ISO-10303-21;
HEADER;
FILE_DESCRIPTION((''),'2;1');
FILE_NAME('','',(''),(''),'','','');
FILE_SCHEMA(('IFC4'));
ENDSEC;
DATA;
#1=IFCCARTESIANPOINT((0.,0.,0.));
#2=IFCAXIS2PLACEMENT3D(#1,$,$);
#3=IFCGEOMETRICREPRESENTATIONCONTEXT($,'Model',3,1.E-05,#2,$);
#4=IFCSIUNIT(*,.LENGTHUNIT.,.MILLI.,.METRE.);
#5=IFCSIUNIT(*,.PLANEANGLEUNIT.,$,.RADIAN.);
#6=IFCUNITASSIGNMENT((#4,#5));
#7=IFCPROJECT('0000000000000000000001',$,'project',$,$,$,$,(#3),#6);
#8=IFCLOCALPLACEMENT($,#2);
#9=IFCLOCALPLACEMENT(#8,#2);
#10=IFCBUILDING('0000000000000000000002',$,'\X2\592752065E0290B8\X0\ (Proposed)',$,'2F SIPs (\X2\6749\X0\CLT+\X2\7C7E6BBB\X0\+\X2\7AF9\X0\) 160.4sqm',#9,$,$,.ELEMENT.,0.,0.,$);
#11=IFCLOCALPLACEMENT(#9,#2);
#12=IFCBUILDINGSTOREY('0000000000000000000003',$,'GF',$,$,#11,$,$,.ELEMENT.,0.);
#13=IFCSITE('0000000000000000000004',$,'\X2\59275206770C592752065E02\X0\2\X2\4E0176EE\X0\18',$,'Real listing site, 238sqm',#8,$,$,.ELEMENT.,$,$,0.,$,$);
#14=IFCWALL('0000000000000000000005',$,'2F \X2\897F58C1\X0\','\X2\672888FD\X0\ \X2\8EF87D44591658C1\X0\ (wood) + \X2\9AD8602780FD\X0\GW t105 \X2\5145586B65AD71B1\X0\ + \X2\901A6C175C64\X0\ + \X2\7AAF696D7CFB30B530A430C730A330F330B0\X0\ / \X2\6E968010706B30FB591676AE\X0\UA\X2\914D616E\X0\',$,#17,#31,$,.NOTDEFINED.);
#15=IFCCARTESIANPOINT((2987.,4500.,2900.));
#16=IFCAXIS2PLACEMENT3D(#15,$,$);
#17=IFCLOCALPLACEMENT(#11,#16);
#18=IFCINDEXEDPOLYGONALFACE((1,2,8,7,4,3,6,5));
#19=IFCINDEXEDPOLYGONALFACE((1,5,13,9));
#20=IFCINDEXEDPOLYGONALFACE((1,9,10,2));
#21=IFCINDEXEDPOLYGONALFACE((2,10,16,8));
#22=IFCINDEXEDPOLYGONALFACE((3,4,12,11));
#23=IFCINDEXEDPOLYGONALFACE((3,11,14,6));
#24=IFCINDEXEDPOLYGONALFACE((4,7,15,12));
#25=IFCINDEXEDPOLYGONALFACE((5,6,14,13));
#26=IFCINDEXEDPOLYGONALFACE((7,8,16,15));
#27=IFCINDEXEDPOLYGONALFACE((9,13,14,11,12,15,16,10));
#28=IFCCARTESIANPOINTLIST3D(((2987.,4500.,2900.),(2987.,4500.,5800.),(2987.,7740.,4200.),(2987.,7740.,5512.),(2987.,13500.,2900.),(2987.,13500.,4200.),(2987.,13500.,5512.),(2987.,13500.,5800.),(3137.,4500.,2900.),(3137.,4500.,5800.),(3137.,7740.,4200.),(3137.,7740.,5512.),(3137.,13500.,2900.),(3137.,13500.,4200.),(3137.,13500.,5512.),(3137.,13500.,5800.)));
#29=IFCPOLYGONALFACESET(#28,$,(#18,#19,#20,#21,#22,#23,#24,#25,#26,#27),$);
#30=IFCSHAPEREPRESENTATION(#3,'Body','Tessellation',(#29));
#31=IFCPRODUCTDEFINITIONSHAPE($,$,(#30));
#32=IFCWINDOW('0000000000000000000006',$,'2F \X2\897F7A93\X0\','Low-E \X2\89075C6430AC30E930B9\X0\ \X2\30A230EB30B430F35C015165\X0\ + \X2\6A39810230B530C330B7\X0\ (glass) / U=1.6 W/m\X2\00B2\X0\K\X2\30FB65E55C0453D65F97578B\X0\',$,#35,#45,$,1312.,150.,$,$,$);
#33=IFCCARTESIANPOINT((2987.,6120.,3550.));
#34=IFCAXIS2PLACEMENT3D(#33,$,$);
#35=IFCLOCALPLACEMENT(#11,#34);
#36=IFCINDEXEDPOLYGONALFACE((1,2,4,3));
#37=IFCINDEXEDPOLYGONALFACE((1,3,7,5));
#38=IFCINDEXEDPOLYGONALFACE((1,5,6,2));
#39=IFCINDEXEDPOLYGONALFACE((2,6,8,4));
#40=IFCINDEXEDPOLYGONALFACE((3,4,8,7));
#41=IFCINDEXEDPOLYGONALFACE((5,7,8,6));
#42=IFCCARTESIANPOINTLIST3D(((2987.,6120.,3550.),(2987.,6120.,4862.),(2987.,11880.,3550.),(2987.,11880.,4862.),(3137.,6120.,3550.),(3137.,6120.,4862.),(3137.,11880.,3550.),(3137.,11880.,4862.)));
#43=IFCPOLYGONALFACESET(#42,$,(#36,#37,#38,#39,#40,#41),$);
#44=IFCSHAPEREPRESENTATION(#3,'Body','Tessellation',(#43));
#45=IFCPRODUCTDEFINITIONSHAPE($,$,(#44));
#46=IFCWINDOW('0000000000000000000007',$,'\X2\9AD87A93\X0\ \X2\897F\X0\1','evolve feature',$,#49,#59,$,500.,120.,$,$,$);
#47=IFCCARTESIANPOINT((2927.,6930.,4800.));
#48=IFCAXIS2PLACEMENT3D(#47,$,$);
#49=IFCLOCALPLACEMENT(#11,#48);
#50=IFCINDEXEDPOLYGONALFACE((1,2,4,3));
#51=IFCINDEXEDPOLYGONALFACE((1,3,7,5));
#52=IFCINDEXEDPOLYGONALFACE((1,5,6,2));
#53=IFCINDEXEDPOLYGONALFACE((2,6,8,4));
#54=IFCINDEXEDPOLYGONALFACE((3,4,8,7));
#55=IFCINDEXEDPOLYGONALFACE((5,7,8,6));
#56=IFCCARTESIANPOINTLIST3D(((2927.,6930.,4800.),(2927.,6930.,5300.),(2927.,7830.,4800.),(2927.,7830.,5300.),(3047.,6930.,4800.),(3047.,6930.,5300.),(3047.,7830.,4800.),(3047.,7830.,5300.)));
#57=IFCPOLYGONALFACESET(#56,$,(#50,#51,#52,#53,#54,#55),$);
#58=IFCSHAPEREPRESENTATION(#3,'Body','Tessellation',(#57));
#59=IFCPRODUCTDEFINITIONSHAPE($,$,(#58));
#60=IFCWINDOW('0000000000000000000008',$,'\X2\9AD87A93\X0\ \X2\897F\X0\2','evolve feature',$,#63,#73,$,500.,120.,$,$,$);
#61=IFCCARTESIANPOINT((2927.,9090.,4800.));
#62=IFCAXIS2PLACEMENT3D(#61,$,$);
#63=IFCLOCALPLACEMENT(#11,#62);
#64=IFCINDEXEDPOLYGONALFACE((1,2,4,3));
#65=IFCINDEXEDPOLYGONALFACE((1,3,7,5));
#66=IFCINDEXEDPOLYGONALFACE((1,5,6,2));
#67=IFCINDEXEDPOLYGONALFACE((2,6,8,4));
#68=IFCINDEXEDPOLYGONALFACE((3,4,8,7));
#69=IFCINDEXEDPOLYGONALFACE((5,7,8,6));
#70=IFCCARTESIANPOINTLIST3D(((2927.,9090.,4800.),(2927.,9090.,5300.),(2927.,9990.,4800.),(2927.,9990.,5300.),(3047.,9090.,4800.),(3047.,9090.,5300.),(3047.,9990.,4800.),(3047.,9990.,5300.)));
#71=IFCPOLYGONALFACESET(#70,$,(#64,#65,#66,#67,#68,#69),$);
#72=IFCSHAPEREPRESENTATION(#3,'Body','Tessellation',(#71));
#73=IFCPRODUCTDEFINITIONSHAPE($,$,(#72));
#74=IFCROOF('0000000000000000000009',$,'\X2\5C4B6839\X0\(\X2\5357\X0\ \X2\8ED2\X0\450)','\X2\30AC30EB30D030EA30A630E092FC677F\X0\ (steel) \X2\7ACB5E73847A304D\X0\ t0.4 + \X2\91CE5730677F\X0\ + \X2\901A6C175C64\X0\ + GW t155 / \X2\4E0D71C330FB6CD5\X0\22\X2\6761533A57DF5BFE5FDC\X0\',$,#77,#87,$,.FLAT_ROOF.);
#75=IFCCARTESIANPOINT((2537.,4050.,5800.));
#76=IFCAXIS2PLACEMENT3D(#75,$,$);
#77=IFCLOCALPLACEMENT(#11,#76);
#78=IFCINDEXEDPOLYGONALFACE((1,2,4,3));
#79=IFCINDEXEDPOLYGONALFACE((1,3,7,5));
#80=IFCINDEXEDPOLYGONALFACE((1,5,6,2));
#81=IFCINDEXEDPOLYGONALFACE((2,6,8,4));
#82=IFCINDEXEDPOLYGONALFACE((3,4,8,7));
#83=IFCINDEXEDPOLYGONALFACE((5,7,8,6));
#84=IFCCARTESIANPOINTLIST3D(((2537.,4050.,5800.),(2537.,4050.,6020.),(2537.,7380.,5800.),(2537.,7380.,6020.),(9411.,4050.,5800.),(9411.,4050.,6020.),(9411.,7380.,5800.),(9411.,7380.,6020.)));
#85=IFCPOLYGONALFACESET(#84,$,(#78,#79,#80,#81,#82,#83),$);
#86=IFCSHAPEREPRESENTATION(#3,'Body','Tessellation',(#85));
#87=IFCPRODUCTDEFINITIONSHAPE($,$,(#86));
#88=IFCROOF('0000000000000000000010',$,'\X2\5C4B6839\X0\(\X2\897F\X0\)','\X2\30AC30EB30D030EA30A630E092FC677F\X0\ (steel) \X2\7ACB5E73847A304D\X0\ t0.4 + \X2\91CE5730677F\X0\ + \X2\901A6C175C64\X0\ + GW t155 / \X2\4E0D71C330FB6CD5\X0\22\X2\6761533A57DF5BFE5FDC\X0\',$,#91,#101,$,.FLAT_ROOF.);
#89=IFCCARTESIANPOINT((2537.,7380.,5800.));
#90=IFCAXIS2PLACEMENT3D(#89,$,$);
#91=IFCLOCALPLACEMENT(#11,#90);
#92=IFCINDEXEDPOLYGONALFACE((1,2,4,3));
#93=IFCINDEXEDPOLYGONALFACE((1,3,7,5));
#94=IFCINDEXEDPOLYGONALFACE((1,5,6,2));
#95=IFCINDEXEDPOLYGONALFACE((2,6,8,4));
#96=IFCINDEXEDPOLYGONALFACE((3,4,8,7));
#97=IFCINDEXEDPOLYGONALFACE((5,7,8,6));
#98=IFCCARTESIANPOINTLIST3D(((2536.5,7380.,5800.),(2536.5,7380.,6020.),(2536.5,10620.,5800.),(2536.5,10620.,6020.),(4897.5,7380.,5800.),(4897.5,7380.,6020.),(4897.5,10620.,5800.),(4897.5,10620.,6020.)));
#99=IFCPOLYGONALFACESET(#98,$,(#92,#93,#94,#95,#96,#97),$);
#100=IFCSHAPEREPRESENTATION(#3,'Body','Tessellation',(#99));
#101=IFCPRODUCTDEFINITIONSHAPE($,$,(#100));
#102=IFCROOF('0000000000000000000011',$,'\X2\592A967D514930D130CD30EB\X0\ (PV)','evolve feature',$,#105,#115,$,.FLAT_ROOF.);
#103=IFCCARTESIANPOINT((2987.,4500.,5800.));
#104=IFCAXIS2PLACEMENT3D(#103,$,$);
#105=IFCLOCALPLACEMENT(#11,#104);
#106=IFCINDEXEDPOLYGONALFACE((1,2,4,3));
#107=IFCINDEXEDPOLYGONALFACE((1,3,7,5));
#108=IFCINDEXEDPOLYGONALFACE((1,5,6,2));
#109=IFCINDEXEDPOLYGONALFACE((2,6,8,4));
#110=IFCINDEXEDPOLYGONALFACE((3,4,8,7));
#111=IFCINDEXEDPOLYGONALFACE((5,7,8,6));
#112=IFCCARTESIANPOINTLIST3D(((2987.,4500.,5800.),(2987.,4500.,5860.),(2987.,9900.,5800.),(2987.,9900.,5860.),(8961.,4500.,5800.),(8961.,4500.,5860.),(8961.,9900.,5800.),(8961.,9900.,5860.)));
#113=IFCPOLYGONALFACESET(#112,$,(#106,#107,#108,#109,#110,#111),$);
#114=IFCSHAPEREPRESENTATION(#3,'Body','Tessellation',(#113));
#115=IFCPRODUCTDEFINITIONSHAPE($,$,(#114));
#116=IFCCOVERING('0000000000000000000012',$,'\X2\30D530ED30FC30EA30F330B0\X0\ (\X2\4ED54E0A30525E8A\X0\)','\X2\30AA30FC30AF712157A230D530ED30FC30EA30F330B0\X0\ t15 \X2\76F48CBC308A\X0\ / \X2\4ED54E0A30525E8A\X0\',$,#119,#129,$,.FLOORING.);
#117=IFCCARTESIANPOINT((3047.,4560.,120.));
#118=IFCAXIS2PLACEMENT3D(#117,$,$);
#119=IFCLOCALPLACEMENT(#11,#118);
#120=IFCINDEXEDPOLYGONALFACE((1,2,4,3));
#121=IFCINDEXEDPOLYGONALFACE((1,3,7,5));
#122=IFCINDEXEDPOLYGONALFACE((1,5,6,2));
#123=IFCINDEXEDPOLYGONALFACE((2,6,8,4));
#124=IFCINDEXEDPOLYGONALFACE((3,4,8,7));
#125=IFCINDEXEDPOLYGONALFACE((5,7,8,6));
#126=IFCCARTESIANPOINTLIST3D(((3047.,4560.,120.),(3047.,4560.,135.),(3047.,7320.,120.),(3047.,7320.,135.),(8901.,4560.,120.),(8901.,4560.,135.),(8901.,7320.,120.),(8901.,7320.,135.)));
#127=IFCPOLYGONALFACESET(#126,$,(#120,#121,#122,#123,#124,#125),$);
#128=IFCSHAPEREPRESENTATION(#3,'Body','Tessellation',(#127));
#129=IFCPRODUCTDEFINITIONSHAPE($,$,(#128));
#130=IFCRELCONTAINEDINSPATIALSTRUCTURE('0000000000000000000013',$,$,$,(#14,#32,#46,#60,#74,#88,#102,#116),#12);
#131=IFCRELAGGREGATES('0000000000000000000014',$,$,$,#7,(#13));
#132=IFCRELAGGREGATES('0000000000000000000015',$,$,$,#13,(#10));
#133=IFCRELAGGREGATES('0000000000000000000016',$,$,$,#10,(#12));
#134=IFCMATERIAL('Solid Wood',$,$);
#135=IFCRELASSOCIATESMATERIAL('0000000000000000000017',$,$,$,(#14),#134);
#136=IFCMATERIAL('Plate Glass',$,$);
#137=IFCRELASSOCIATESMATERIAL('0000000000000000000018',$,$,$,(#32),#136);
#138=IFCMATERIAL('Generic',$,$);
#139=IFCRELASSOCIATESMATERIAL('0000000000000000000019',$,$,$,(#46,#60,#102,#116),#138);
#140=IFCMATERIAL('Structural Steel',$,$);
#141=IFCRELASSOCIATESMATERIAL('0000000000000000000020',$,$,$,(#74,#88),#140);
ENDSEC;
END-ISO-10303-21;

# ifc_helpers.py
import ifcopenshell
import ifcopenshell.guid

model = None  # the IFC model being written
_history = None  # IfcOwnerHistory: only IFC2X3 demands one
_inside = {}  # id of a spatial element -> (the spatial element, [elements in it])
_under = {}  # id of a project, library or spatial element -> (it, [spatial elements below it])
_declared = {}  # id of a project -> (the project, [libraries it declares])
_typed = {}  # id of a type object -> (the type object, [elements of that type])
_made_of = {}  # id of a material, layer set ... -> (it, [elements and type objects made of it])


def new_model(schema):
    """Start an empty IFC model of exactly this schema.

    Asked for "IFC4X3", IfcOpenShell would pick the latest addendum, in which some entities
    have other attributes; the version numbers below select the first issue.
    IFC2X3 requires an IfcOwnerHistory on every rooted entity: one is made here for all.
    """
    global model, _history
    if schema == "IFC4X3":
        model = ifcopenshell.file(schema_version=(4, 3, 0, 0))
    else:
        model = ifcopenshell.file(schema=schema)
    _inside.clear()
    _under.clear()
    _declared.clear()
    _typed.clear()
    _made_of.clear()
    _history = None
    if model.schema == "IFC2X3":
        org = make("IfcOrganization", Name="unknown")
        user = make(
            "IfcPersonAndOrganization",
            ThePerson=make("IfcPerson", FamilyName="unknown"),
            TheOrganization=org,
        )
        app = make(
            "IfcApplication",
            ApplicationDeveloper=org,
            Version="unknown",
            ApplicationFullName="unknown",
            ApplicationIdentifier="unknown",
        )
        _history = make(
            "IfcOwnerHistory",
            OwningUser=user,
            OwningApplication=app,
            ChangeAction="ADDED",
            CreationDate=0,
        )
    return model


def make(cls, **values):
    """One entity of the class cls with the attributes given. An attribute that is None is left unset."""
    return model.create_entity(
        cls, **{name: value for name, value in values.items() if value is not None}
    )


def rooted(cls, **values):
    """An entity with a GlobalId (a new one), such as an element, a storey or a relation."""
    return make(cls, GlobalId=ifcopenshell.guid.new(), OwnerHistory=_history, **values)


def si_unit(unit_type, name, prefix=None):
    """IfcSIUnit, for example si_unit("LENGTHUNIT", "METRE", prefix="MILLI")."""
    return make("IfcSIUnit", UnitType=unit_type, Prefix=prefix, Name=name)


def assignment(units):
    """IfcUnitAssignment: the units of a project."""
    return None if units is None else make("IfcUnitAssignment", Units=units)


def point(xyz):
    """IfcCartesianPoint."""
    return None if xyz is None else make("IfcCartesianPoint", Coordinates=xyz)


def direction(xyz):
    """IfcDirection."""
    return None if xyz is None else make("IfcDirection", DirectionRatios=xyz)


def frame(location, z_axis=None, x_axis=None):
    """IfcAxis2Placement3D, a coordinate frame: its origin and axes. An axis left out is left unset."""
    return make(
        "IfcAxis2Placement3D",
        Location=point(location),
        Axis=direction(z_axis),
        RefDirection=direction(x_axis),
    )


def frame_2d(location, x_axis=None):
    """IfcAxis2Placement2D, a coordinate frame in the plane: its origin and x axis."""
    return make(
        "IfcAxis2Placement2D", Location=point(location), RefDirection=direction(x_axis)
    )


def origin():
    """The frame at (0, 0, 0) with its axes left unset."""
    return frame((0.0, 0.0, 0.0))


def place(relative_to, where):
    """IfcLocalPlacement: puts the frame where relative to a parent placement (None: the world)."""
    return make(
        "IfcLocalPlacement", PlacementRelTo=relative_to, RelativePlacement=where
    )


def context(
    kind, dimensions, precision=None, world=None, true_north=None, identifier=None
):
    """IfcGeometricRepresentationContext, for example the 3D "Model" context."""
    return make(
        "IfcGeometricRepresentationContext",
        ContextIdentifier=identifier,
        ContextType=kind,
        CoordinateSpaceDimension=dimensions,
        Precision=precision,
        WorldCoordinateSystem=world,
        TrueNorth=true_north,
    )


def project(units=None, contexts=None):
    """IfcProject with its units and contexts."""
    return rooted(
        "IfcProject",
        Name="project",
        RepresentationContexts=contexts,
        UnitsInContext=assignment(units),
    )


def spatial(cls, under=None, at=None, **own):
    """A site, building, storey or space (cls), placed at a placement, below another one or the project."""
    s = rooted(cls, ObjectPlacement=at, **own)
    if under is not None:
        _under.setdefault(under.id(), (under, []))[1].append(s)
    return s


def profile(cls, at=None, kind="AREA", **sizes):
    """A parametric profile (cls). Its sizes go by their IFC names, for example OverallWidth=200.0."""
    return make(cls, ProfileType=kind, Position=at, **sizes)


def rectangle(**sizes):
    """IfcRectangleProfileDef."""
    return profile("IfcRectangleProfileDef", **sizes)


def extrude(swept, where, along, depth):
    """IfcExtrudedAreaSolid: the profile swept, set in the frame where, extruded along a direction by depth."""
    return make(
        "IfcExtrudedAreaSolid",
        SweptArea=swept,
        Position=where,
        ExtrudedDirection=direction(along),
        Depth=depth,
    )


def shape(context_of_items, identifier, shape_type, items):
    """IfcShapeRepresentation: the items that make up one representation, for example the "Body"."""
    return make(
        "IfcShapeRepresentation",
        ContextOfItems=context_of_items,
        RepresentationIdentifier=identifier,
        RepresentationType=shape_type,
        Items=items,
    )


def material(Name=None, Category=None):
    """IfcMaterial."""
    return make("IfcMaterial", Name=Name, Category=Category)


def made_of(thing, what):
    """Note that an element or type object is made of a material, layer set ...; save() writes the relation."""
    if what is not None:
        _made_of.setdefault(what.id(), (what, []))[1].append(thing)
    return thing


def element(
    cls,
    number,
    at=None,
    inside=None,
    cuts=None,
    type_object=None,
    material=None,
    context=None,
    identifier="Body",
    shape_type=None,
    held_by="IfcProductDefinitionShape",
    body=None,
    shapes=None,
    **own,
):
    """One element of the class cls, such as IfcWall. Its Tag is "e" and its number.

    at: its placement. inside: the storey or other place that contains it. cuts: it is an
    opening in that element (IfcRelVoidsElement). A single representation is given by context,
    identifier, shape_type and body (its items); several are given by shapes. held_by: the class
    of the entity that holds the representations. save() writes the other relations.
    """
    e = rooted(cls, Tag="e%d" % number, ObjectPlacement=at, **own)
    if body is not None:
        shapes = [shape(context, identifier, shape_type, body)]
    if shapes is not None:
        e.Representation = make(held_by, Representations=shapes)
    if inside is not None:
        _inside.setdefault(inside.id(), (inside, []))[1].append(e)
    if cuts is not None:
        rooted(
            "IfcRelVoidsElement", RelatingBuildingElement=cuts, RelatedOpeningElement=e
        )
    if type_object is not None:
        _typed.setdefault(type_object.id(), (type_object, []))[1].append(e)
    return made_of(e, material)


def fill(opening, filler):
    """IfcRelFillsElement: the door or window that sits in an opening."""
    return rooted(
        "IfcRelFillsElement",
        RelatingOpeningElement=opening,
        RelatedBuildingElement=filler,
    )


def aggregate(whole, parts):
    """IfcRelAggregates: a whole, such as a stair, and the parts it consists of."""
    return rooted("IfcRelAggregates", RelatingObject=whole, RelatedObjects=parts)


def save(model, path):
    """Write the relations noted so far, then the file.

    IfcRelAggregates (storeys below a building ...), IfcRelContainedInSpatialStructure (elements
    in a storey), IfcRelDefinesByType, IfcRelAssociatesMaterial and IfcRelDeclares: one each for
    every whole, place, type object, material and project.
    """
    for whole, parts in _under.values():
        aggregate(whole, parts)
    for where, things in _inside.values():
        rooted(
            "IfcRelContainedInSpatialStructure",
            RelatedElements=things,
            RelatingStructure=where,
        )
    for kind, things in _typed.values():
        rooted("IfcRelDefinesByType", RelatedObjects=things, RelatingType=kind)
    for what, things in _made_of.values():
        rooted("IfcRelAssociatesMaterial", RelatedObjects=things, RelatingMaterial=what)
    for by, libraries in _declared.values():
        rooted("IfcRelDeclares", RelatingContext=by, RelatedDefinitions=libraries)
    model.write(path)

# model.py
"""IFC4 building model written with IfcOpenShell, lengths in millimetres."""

from ifc_helpers import new_model, si_unit, frame, frame_2d, origin, place, context, project, spatial, rectangle, extrude, material, element, fill, save


model = new_model("IFC4")

# Units and contexts
model_context = context("Model", 3, precision=1e-05, world=origin())
ifc_project = project(units=[si_unit("LENGTHUNIT", "METRE", prefix="MILLI"), si_unit("PLANEANGLEUNIT", "RADIAN")], contexts=[model_context])

# Site, building, storey
site_placement = place(None, origin())
site = spatial("IfcSite", under=ifc_project, at=site_placement, Name="大分県大分市2丁目18", ObjectType="Real listing site, 238sqm", CompositionType="ELEMENT", RefElevation=0.0)
building_placement = place(site_placement, origin())
building = spatial("IfcBuilding", under=site, at=building_placement, Name="大分市邸 (Proposed)", ObjectType="2F SIPs (杉CLT+籾殻+竹) 160.4sqm", CompositionType="ELEMENT", ElevationOfRefHeight=0.0, ElevationOfTerrain=0.0)
storey_placement = place(building_placement, origin())
storey = spatial("IfcBuildingStorey", under=building, at=storey_placement, Name="GF", CompositionType="ELEMENT", Elevation=0.0)

# Shared definitions
ifc_material_1 = material(Name="Solid Wood")
ifc_material_2 = material(Name="Generic")

# Shared definitions
ifc_material_3 = material(Name="Plate Glass")

# Wall, openings, windows
wall_1_placement = place(storey_placement, frame((2987.0, 4500.0, 2900.0)))
wall_1 = element("IfcWall", 1, at=wall_1_placement, inside=storey, material=ifc_material_1, Name="2F 西壁", Description="木製 軸組外壁 (wood) + 高性能GW t105 充填断熱 + 通気層 + 窯業系サイディング / 準耐火・外皮UA配慮", PredefinedType="NOTDEFINED", context=model_context, shape_type="SweptSolid", body=[
    extrude(rectangle(XDim=150.0, YDim=9000.0, at=frame_2d((75.0, 4500.0))), frame((2987.0, 4500.0, 2900.0)), (0.0, 0.0, 1.0), 2900.0),
])
opening_1_placement = place(storey_placement, frame((2987.0, 6120.0, 3550.0)))
opening_1 = element("IfcOpeningElement", 2, at=opening_1_placement, cuts=wall_1, PredefinedType="NOTDEFINED", context=model_context, shape_type="SweptSolid", body=[
    extrude(rectangle(XDim=150.0, YDim=5760.0, at=frame_2d((75.0, 2880.0))), frame((2987.0, 6120.0, 3550.0)), (0.0, 0.0, 1.0), 1312.0),
])
opening_2_placement = place(storey_placement, frame((2927.0, 6930.0, 4800.0)))
opening_2 = element("IfcOpeningElement", 3, at=opening_2_placement, cuts=wall_1, PredefinedType="NOTDEFINED", context=model_context, shape_type="SweptSolid", body=[
    extrude(rectangle(XDim=120.0, YDim=900.0, at=frame_2d((60.0, 450.0))), frame((2927.0, 6930.0, 4800.0)), (0.0, 0.0, 1.0), 500.0),
])
opening_3_placement = place(storey_placement, frame((2927.0, 9090.0, 4800.0)))
opening_3 = element("IfcOpeningElement", 4, at=opening_3_placement, cuts=wall_1, PredefinedType="NOTDEFINED", context=model_context, shape_type="SweptSolid", body=[
    extrude(rectangle(XDim=120.0, YDim=900.0, at=frame_2d((60.0, 450.0))), frame((2927.0, 9090.0, 4800.0)), (0.0, 0.0, 1.0), 500.0),
])
window_1_placement = place(storey_placement, frame((2987.0, 6120.0, 3550.0)))
window_1 = element("IfcWindow", 5, at=window_1_placement, inside=storey, material=ifc_material_3, Name="2F 西窓", Description="Low-E 複層ガラス アルゴン封入 + 樹脂サッシ (glass) / U=1.6 W/m²K・日射取得型", OverallHeight=1312.0, OverallWidth=150.0, context=model_context, shape_type="SweptSolid", body=[
    extrude(rectangle(XDim=150.0, YDim=5760.0, at=frame_2d((75.0, 2880.0))), frame((2987.0, 6120.0, 3550.0)), (0.0, 0.0, 1.0), 1312.0),
])
fill(opening_1, window_1)
window_2_placement = place(storey_placement, frame((2927.0, 6930.0, 4800.0)))
window_2 = element("IfcWindow", 6, at=window_2_placement, inside=storey, material=ifc_material_2, Name="高窓 西1", Description="evolve feature", OverallHeight=500.0, OverallWidth=120.0, context=model_context, shape_type="SweptSolid", body=[
    extrude(rectangle(XDim=120.0, YDim=900.0, at=frame_2d((60.0, 450.0))), frame((2927.0, 6930.0, 4800.0)), (0.0, 0.0, 1.0), 500.0),
])
fill(opening_2, window_2)
window_3_placement = place(storey_placement, frame((2927.0, 9090.0, 4800.0)))
window_3 = element("IfcWindow", 7, at=window_3_placement, inside=storey, material=ifc_material_2, Name="高窓 西2", Description="evolve feature", OverallHeight=500.0, OverallWidth=120.0, context=model_context, shape_type="SweptSolid", body=[
    extrude(rectangle(XDim=120.0, YDim=900.0, at=frame_2d((60.0, 450.0))), frame((2927.0, 9090.0, 4800.0)), (0.0, 0.0, 1.0), 500.0),
])
fill(opening_3, window_3)

# Roofs
ifc_material_4 = material(Name="Structural Steel")
roof_1_placement = place(storey_placement, frame((2537.0, 4050.0, 5800.0)))
element("IfcRoof", 8, at=roof_1_placement, inside=storey, material=ifc_material_4, Name="屋根(南 軒450)", Description="ガルバリウム鋼板 (steel) 立平葺き t0.4 + 野地板 + 通気層 + GW t155 / 不燃・法22条区域対応", PredefinedType="FLAT_ROOF", context=model_context, shape_type="SweptSolid", body=[
    extrude(rectangle(XDim=6874.0, YDim=3330.0, at=frame_2d((3437.0, 1665.0))), frame((2537.0, 4050.0, 5800.0)), (0.0, 0.0, 1.0), 220.0),
])
roof_2_placement = place(storey_placement, frame((2537.0, 7380.0, 5800.0)))
element("IfcRoof", 9, at=roof_2_placement, inside=storey, material=ifc_material_4, Name="屋根(西)", Description="ガルバリウム鋼板 (steel) 立平葺き t0.4 + 野地板 + 通気層 + GW t155 / 不燃・法22条区域対応", PredefinedType="FLAT_ROOF", context=model_context, shape_type="SweptSolid", body=[
    extrude(rectangle(XDim=2361.0, YDim=3240.0, at=frame_2d((1180.0, 1620.0))), frame((2537.0, 7380.0, 5800.0)), (0.0, 0.0, 1.0), 220.0),
])
roof_3_placement = place(storey_placement, frame((2987.0, 4500.0, 5800.0)))
element("IfcRoof", 10, at=roof_3_placement, inside=storey, material=ifc_material_2, Name="太陽光パネル (PV)", Description="evolve feature", PredefinedType="FLAT_ROOF", context=model_context, shape_type="SweptSolid", body=[
    extrude(rectangle(XDim=5974.0, YDim=5400.0, at=frame_2d((2987.0, 2700.0))), frame((2987.0, 4500.0, 5800.0)), (0.0, 0.0, 1.0), 60.0),
])

# Covering
covering_placement = place(storey_placement, frame((3047.0, 4560.0, 120.0)))
element("IfcCovering", 11, at=covering_placement, inside=storey, material=ifc_material_2, Name="フローリング (仕上げ床)", Description="オーク無垢フローリング t15 直貼り / 仕上げ床", PredefinedType="FLOORING", context=model_context, shape_type="SweptSolid", body=[
    extrude(rectangle(XDim=5854.0, YDim=2760.0, at=frame_2d((2927.0, 1380.0))), frame((3047.0, 4560.0, 120.0)), (0.0, 0.0, 1.0), 15.0),
])

save(model, "model.ifc")
